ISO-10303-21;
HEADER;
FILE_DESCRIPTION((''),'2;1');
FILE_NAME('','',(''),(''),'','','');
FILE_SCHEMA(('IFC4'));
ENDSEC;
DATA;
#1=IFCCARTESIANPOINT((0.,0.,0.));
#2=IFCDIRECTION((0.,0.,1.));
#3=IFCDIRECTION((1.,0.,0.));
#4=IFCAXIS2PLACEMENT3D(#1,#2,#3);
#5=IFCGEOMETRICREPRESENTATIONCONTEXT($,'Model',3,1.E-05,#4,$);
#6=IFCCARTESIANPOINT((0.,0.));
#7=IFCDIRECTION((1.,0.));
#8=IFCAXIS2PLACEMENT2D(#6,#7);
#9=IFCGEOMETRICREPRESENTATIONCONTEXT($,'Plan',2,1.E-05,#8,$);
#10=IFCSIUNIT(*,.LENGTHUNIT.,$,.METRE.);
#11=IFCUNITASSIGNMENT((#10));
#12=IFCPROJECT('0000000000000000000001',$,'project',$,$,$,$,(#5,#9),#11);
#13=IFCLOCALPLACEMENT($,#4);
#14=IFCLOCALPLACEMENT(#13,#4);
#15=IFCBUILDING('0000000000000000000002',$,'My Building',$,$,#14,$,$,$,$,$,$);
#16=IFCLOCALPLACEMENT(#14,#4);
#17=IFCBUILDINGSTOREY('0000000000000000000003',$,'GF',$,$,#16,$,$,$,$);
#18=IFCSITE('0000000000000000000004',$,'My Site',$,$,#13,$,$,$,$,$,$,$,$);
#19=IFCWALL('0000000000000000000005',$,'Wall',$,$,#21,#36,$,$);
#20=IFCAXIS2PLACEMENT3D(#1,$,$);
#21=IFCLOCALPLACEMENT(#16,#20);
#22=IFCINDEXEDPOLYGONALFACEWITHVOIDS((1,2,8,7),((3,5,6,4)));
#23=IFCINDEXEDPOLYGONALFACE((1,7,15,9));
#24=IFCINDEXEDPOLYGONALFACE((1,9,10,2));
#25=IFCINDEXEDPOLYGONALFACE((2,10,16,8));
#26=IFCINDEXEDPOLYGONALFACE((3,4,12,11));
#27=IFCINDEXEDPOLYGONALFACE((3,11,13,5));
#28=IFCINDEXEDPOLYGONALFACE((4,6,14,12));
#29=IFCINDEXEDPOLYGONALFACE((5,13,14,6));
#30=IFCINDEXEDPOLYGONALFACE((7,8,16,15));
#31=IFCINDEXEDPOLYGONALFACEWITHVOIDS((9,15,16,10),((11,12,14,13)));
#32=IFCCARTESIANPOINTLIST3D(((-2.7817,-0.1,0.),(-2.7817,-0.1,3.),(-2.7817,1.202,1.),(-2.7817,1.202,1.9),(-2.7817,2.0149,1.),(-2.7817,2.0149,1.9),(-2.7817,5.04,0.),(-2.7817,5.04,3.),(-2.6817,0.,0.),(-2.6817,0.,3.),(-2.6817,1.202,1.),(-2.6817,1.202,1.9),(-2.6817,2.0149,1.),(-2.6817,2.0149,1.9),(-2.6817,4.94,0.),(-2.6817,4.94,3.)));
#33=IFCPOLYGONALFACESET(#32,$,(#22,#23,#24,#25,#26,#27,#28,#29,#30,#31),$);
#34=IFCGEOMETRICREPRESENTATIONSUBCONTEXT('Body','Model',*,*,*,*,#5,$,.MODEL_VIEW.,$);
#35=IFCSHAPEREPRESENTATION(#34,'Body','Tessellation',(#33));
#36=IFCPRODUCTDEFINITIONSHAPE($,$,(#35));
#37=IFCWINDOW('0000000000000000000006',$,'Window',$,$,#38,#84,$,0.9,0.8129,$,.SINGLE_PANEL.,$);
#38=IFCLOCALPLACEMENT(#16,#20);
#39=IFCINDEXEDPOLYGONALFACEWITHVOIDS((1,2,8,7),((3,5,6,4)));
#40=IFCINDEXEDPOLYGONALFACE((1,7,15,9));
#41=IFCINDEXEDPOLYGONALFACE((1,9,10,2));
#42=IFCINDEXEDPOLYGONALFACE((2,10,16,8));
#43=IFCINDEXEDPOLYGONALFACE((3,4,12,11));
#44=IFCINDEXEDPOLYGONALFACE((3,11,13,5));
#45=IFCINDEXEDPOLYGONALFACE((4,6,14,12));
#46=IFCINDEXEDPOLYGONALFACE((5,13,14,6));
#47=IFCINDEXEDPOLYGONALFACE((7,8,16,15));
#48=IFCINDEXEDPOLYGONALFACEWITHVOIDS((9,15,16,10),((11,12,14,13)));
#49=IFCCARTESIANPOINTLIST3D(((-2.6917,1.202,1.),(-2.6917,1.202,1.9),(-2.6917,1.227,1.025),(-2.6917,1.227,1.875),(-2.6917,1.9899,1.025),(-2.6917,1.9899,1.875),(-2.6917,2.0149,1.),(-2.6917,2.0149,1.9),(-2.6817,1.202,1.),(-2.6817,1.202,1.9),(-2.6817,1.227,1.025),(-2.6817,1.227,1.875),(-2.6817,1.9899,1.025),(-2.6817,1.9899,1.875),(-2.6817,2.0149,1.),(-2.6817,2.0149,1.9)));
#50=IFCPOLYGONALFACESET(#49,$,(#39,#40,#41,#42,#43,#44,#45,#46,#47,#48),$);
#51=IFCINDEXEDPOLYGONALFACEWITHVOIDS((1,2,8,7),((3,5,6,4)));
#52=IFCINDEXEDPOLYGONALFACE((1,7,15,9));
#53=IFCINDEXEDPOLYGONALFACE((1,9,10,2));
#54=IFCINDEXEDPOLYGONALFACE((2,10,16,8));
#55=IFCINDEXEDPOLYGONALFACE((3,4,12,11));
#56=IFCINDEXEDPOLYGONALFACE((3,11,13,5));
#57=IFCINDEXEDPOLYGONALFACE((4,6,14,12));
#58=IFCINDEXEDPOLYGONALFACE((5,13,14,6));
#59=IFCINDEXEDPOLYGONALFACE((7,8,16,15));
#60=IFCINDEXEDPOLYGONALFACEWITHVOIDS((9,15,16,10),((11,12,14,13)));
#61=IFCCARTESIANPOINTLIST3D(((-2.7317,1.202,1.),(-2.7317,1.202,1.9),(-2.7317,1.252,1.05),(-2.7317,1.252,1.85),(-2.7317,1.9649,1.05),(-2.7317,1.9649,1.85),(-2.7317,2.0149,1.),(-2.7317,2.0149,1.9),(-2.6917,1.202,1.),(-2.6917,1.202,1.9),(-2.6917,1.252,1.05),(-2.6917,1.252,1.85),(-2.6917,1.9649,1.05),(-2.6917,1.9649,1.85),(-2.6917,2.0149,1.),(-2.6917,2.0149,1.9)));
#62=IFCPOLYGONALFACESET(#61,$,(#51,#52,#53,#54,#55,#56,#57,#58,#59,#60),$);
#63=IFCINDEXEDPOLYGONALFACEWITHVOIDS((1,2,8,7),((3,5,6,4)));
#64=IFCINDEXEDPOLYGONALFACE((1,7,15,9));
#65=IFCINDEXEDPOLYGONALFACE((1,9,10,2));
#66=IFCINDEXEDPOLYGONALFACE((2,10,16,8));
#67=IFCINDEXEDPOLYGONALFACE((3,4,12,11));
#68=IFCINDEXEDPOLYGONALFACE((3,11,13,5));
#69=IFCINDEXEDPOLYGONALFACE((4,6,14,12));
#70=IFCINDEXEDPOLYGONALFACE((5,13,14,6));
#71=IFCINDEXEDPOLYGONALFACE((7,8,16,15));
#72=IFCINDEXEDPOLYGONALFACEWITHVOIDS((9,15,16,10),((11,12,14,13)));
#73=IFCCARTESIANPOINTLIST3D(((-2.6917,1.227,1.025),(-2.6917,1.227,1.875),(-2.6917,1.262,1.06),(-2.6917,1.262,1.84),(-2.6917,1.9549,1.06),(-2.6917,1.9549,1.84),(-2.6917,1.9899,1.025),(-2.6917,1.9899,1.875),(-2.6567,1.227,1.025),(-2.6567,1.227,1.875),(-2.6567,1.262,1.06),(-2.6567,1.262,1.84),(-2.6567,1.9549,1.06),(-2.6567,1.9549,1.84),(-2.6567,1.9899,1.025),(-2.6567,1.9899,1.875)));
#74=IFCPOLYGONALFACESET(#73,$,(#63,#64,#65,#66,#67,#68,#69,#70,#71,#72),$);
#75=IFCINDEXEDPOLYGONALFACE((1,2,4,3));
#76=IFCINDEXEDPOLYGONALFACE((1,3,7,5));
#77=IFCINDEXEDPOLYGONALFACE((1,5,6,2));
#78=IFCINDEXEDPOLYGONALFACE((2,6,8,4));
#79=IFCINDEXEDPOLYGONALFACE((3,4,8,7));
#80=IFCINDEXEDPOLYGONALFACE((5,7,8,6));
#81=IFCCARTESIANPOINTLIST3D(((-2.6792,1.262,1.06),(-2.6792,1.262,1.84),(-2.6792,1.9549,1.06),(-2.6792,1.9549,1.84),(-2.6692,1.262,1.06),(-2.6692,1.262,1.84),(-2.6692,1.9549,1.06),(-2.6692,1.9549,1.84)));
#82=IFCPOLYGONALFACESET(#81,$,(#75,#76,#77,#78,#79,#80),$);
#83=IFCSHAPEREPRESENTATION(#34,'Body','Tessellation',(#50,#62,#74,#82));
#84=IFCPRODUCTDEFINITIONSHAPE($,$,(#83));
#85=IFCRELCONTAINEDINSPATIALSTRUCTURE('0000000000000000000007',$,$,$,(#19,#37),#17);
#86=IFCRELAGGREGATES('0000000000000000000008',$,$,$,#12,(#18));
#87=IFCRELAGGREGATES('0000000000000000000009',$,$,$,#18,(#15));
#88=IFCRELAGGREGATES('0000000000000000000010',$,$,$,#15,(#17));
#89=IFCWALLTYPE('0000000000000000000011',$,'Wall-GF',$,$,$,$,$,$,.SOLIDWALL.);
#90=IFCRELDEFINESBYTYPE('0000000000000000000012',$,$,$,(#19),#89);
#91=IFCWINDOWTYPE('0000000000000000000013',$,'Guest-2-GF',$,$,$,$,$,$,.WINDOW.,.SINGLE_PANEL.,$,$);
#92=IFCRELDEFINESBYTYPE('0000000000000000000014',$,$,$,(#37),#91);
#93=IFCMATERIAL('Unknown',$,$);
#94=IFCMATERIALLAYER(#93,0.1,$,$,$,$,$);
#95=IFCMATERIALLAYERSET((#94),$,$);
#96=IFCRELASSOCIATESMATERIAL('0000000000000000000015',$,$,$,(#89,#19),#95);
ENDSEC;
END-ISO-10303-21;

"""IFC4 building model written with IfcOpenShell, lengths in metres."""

from ifc_helpers import new_model, entity, si_unit, frame, origin_with_axes, origin_2d_with_axis, place, context, subcontext, project, spatial, line, indexed_curve, outline, extrude, shape, source, transform, mapped, material, layer, layer_set, layer_usage, type_object, type_shapes, element, fill, save


model = new_model("IFC4")

# Units and contexts
model_context = context("Model", 3, precision=1e-05, world=origin_with_axes())
plan_context = context("Plan", 2, precision=1e-05, world=origin_2d_with_axis())
body_context_1 = subcontext(model_context, "Body", "Model", "MODEL_VIEW")
body_context_2 = subcontext(plan_context, "Body", "Plan", "PLAN_VIEW")
ifc_project = project(units=[si_unit("LENGTHUNIT", "METRE")], contexts=[model_context, plan_context])

# Site, building, storey
site_placement = place(None, origin_with_axes())
site = spatial("IfcSite", under=ifc_project, at=site_placement, Name="My Site")
building_placement = place(site_placement, origin_with_axes())
building = spatial("IfcBuilding", under=site, at=building_placement, Name="My Building")
storey_placement = place(building_placement, origin_with_axes())
storey = spatial("IfcBuildingStorey", under=building, at=storey_placement, Name="GF")

# Shared definitions
ifc_material = material(Name="Unknown")

# Shared definitions
ifc_layer_1 = layer(ifc_material, 0.1)
ifc_layer_set_1 = layer_set([ifc_layer_1])
wall_type = type_object("IfcWallType", Name="Wall-GF", PredefinedType="SOLIDWALL", material=ifc_layer_set_1)

# Wall, opening, window
ifc_layer_usage_1 = layer_usage(ifc_layer_set_1, "AXIS2", "POSITIVE", 0.0)
wall_1_placement = place(storey_placement, frame((-2.7817, 5.04, 0.0), z_axis=(0.0, 0.0, 1.0), x_axis=(0.0, -1.0, 0.0)))
wall_1 = element("IfcWall", 1, at=wall_1_placement, inside=storey, type_object=wall_type, material=ifc_layer_usage_1, Name="Wall", context=body_context_1, shape_type="SweptSolid", body=[
    extrude(outline(indexed_curve([(0.0, 0.0), (0.1, 0.1), (5.04, 0.1), (5.14, 0.0)], segments=[line(1, 2, 3, 4, 1)])), origin_with_axes(), (0.0, 0.0, 1.0), 3.0),
])
shared_shape_1 = source(origin_with_axes(), body_context_1, "Body", "SweptSolid", [
    extrude(outline(indexed_curve([(0.0, 0.0), (0.8129, 0.0), (0.8129, 0.9), (0.0, 0.9)], segments=[line(1, 2, 3, 4, 1)])), frame((0.0, -0.6, 0.0), z_axis=(0.0, -1.0, 0.0), x_axis=(1.0, 0.0, 0.0)), (0.0, 0.0, -1.0), 1.2),
])
opening_1_placement = place(wall_1_placement, frame((3.0251, 0.0, 1.0), z_axis=(0.0, 0.0, 1.0), x_axis=(1.0, 0.0, 0.0)))
opening_1 = element("IfcOpeningElement", 2, at=opening_1_placement, cuts=wall_1, PredefinedType="OPENING", context=body_context_1, shape_type="MappedRepresentation", body=[
    mapped(shared_shape_1, transform((0.0, 0.0, 0.0), x_axis=(1.0, 0.0, 0.0), y_axis=(0.0, 1.0, 0.0), z_axis=(0.0, 0.0, 1.0), scale=1.0)),
])
window_type_1 = type_object("IfcWindowType", Name="Guest-2-GF", PartitioningType="SINGLE_PANEL", PredefinedType="WINDOW")
shared_shape_2 = source(origin_with_axes(), body_context_1, "Body", "SweptSolid", [
    extrude(outline(indexed_curve([(0.0, 0.0), (0.8129, 0.0), (0.8129, 0.9), (0.0, 0.9)], segments=[line(1, 2, 3, 4, 1)]), holes=[indexed_curve([(0.025, 0.025), (0.7879, 0.025), (0.7879, 0.875), (0.025, 0.875)], segments=[line(1, 2, 3, 4, 1)])]), frame((0.0, 0.09, 0.0), z_axis=(0.0, -1.0, 0.0), x_axis=(1.0, 0.0, 0.0)), (0.0, 0.0, -1.0), 0.01),
    extrude(outline(indexed_curve([(0.0, 0.0), (0.8129, 0.0), (0.8129, 0.9), (0.0, 0.9)], segments=[line(1, 2, 3, 4, 1)]), holes=[indexed_curve([(0.05, 0.05), (0.7629, 0.05), (0.7629, 0.85), (0.05, 0.85)], segments=[line(1, 2, 3, 4, 1)])]), frame((0.0, 0.05, 0.0), z_axis=(0.0, -1.0, 0.0), x_axis=(1.0, 0.0, 0.0)), (0.0, 0.0, -1.0), 0.04),
    extrude(outline(indexed_curve([(0.0, 0.0), (0.7629, 0.0), (0.7629, 0.85), (0.0, 0.85)], segments=[line(1, 2, 3, 4, 1)]), holes=[indexed_curve([(0.035, 0.035), (0.7279, 0.035), (0.7279, 0.815), (0.035, 0.815)], segments=[line(1, 2, 3, 4, 1)])]), frame((0.025, 0.09, 0.025), z_axis=(0.0, -1.0, 0.0), x_axis=(1.0, 0.0, 0.0)), (0.0, 0.0, -1.0), 0.035),
    extrude(outline(indexed_curve([(0.035, 0.035), (0.7279, 0.035), (0.7279, 0.815), (0.035, 0.815)], segments=[line(1, 2, 3, 4, 1)])), frame((0.025, 0.1025, 0.025), z_axis=(0.0, -1.0, 0.0), x_axis=(1.0, 0.0, 0.0)), (0.0, 0.0, -1.0), 0.01),
])
shared_shape_3 = source(origin_with_axes(), body_context_2, "Body", "Curve2D", [
    entity("IfcIndexedPolyCurve", entity("IfcCartesianPointList2D", [[0.05, 0.05], [0.7629, 0.05]])),
    entity("IfcIndexedPolyCurve", entity("IfcCartesianPointList2D", [[0.0, 0.1], [0.025, 0.1], [0.025, 0.09], [0.05, 0.09], [0.05, 0.05], [0.0, 0.05]]), [entity("IfcLineIndex", [1, 2, 3, 4, 5, 6, 1])]),
    entity("IfcIndexedPolyCurve", entity("IfcCartesianPointList2D", [[0.8129, 0.1], [0.7879, 0.1], [0.7879, 0.09], [0.7629, 0.09], [0.7629, 0.05], [0.8129, 0.05]]), [entity("IfcLineIndex", [1, 2, 3, 4, 5, 6, 1])]),
    entity("IfcIndexedPolyCurve", entity("IfcCartesianPointList2D", [[0.025, 0.09], [0.06, 0.09], [0.06, 0.125], [0.025, 0.125]]), [entity("IfcLineIndex", [1, 2, 3, 4, 1])]),
    entity("IfcIndexedPolyCurve", entity("IfcCartesianPointList2D", [[0.7879, 0.09], [0.7529, 0.09], [0.7529, 0.125], [0.7879, 0.125]]), [entity("IfcLineIndex", [1, 2, 3, 4, 1])]),
    entity("IfcIndexedPolyCurve", entity("IfcCartesianPointList2D", [[0.06, 0.09], [0.7529, 0.09]])),
    entity("IfcIndexedPolyCurve", entity("IfcCartesianPointList2D", [[0.06, 0.125], [0.7529, 0.125]])),
    entity("IfcIndexedPolyCurve", entity("IfcCartesianPointList2D", [[0.06, 0.1075], [0.7529, 0.1075]])),
])
type_shapes(window_type_1, [shared_shape_2, shared_shape_3])
window_1_placement = place(opening_1_placement, frame((0.0, 0.0, 0.0), z_axis=(0.0, 0.0, 1.0), x_axis=(1.0, 0.0, 0.0)))
window_1 = element("IfcWindow", 3, at=window_1_placement, inside=storey, type_object=window_type_1, Name="Window", OverallHeight=0.9, OverallWidth=0.8129, PartitioningType="SINGLE_PANEL", shapes=[
    shape(body_context_1, "Body", "MappedRepresentation", [mapped(shared_shape_2, transform((0.0, 0.0, 0.0), x_axis=(1.0, 0.0, 0.0), y_axis=(0.0, 1.0, 0.0), z_axis=(0.0, 0.0, 1.0), scale=1.0))]),
    shape(body_context_2, "Body", "MappedRepresentation", [mapped(shared_shape_3, transform((0.0, 0.0, 0.0), x_axis=(1.0, 0.0, 0.0), y_axis=(0.0, 1.0, 0.0), z_axis=(0.0, 0.0, 1.0), scale=1.0))]),
])
fill(opening_1, window_1)

save(model, "model.ifc")
